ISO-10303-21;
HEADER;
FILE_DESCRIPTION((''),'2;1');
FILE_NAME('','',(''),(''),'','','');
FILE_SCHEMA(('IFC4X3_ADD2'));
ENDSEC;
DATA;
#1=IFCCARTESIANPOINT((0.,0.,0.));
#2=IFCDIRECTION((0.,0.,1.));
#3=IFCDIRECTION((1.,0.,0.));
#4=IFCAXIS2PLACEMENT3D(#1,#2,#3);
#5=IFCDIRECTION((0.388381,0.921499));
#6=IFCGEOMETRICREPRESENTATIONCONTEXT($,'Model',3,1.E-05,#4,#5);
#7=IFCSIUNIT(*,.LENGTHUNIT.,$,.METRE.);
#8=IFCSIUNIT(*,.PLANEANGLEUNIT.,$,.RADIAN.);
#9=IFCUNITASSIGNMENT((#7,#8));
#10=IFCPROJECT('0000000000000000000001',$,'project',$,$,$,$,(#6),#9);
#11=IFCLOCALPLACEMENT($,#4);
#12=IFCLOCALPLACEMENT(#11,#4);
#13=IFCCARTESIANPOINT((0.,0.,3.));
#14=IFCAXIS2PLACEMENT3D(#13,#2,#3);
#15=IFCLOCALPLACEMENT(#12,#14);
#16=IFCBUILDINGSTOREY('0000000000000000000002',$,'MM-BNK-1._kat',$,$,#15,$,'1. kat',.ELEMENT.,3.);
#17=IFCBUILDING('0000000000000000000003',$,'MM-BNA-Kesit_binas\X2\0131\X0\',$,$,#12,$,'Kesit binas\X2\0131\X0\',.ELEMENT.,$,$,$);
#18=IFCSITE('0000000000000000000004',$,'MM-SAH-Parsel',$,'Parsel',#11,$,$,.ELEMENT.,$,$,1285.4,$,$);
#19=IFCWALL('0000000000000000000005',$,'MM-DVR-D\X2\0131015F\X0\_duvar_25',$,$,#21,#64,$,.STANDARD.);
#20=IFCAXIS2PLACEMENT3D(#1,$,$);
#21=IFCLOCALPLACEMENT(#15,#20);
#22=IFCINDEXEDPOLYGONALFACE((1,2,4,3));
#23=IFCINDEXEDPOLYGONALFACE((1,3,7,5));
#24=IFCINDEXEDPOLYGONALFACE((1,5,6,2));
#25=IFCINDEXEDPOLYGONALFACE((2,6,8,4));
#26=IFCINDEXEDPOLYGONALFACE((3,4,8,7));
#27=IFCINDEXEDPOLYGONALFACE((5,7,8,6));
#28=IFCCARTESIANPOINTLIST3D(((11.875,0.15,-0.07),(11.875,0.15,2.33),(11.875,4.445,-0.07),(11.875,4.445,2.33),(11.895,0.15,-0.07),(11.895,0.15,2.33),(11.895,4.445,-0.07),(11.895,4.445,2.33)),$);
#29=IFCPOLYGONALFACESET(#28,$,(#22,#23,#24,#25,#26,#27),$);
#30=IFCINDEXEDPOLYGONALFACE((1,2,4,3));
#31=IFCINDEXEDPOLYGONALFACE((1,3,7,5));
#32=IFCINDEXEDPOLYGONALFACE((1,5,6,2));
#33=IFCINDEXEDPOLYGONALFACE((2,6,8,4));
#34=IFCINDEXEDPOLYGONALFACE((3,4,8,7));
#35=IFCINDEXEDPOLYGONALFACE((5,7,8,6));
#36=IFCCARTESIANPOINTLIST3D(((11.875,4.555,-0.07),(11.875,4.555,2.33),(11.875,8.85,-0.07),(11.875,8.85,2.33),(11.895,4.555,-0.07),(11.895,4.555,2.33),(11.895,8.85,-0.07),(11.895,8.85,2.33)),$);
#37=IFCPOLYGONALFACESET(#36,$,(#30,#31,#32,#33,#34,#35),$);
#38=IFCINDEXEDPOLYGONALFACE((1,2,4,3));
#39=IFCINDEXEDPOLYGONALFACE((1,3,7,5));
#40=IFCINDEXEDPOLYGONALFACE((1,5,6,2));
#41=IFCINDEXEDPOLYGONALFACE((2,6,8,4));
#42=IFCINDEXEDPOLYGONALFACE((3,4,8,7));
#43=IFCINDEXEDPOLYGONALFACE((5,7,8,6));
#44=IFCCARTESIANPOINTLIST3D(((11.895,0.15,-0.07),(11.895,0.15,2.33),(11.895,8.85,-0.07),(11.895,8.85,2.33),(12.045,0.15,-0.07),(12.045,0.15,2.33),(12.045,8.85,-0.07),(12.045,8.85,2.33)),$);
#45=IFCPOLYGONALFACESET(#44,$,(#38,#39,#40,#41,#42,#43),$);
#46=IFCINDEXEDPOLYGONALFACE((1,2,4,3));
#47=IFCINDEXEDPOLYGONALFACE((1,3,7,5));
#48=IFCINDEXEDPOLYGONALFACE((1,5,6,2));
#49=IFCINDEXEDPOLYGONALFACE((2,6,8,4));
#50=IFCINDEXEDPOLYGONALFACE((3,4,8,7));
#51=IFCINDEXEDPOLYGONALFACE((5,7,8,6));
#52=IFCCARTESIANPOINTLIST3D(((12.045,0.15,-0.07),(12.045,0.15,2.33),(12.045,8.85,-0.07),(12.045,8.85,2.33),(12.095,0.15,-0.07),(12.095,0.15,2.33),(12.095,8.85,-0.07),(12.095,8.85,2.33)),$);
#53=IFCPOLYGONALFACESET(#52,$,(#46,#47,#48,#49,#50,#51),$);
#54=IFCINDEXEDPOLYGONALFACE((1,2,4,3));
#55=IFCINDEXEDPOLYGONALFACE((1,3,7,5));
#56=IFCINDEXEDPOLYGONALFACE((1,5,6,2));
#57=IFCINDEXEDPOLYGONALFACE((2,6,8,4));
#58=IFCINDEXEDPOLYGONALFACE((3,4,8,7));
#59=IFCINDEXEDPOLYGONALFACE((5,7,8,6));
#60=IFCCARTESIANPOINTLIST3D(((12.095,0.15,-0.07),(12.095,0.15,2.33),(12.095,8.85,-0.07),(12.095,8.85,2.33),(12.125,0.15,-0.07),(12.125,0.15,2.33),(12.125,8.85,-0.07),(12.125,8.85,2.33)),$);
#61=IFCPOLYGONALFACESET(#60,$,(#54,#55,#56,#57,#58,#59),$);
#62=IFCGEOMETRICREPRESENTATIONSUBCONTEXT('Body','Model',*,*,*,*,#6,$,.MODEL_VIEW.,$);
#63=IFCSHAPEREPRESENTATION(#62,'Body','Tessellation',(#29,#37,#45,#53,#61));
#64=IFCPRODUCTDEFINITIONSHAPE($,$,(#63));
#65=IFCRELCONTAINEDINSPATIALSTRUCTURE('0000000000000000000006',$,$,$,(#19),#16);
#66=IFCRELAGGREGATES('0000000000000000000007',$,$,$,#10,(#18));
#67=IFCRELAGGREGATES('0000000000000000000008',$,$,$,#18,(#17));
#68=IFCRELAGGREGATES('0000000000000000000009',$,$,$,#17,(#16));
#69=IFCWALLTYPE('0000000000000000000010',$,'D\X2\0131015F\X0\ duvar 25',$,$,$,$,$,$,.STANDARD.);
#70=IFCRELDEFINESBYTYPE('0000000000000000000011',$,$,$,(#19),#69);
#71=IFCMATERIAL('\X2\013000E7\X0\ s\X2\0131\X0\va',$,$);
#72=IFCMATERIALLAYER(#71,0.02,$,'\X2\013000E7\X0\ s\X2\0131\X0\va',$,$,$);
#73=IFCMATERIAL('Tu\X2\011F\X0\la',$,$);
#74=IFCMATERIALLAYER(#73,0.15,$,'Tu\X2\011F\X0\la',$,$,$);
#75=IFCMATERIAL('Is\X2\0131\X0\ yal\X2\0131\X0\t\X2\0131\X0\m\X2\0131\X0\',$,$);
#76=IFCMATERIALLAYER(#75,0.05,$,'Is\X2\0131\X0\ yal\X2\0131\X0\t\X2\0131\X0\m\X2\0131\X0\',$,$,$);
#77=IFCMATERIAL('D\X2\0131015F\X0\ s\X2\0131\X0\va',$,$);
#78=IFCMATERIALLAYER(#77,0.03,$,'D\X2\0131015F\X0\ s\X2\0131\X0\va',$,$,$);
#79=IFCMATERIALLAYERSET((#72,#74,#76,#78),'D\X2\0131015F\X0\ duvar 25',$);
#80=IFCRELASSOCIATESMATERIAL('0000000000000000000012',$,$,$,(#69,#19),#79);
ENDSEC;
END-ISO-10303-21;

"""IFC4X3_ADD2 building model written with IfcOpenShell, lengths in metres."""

from ifc_helpers import new_model, si_unit, direction, frame, origin_with_axes, place, context, subcontext, project, spatial, polyline, outline, extrude, material, layer, layer_set, type_object, element, save


model = new_model("IFC4X3_ADD2")

# Units and contexts
model_context = context("Model", 3, precision=1e-05, world=origin_with_axes(), true_north=direction((0.388381, 0.921499)))
body_context = subcontext(model_context, "Body", "Model", "MODEL_VIEW")
ifc_project = project(units=[si_unit("LENGTHUNIT", "METRE"), si_unit("PLANEANGLEUNIT", "RADIAN")], contexts=[model_context])

# Site, building, storey
site_placement = place(None, origin_with_axes())
site = spatial("IfcSite", under=ifc_project, at=site_placement, Name="MM-SAH-Parsel", ObjectType="Parsel", CompositionType="ELEMENT", RefElevation=1285.4)
building_placement = place(site_placement, origin_with_axes())
building = spatial("IfcBuilding", under=site, at=building_placement, Name="MM-BNA-Kesit_binası", LongName="Kesit binası", CompositionType="ELEMENT")
storey_placement = place(building_placement, frame((0.0, 0.0, 3.0), z_axis=(0.0, 0.0, 1.0), x_axis=(1.0, 0.0, 0.0)))
storey = spatial("IfcBuildingStorey", under=building, at=storey_placement, Name="MM-BNK-1._kat", LongName="1. kat", CompositionType="ELEMENT", Elevation=3.0)

# Shared definitions
ifc_material_1 = material(Name="İç sıva")
ifc_layer_1 = layer(ifc_material_1, 0.02, Name="İç sıva")
ifc_material_2 = material(Name="Tuğla")
ifc_layer_2 = layer(ifc_material_2, 0.15, Name="Tuğla")
ifc_material_3 = material(Name="Isı yalıtımı")
ifc_layer_3 = layer(ifc_material_3, 0.05, Name="Isı yalıtımı")
ifc_material_4 = material(Name="Dış sıva")
ifc_layer_4 = layer(ifc_material_4, 0.03, Name="Dış sıva")
ifc_layer_set_1 = layer_set([ifc_layer_1, ifc_layer_2, ifc_layer_3, ifc_layer_4], Name="Dış duvar 25")
wall_type_1 = type_object("IfcWallType", Name="Dış duvar 25", PredefinedType="STANDARD", material=ifc_layer_set_1)

# Wall
wall_1_placement = place(storey_placement, origin_with_axes())
element("IfcWall", 1, at=wall_1_placement, inside=storey, type_object=wall_type_1, material=ifc_layer_set_1, Name="MM-DVR-Dış_duvar_25", PredefinedType="STANDARD", context=body_context, shape_type="SweptSolid", body=[
    extrude(outline(polyline([(11.895, 0.15), (11.895, 4.445), (11.875, 4.445), (11.875, 0.15), (11.895, 0.15)])), frame((0.0, 0.0, -0.07)), (0.0, 0.0, 1.0), 2.4),
    extrude(outline(polyline([(11.895, 4.555), (11.895, 8.85), (11.875, 8.85), (11.875, 4.555), (11.895, 4.555)])), frame((0.0, 0.0, -0.07)), (0.0, 0.0, 1.0), 2.4),
    extrude(outline(polyline([(12.045, 0.15), (12.045, 8.85), (11.895, 8.85), (11.895, 0.15), (12.045, 0.15)])), frame((0.0, 0.0, -0.07)), (0.0, 0.0, 1.0), 2.4),
    extrude(outline(polyline([(12.095, 0.15), (12.095, 8.85), (12.045, 8.85), (12.045, 0.15), (12.095, 0.15)])), frame((0.0, 0.0, -0.07)), (0.0, 0.0, 1.0), 2.4),
    extrude(outline(polyline([(12.125, 0.15), (12.125, 8.85), (12.095, 8.85), (12.095, 0.15), (12.125, 0.15)])), frame((0.0, 0.0, -0.07)), (0.0, 0.0, 1.0), 2.4),
])

save(model, "model.ifc")
